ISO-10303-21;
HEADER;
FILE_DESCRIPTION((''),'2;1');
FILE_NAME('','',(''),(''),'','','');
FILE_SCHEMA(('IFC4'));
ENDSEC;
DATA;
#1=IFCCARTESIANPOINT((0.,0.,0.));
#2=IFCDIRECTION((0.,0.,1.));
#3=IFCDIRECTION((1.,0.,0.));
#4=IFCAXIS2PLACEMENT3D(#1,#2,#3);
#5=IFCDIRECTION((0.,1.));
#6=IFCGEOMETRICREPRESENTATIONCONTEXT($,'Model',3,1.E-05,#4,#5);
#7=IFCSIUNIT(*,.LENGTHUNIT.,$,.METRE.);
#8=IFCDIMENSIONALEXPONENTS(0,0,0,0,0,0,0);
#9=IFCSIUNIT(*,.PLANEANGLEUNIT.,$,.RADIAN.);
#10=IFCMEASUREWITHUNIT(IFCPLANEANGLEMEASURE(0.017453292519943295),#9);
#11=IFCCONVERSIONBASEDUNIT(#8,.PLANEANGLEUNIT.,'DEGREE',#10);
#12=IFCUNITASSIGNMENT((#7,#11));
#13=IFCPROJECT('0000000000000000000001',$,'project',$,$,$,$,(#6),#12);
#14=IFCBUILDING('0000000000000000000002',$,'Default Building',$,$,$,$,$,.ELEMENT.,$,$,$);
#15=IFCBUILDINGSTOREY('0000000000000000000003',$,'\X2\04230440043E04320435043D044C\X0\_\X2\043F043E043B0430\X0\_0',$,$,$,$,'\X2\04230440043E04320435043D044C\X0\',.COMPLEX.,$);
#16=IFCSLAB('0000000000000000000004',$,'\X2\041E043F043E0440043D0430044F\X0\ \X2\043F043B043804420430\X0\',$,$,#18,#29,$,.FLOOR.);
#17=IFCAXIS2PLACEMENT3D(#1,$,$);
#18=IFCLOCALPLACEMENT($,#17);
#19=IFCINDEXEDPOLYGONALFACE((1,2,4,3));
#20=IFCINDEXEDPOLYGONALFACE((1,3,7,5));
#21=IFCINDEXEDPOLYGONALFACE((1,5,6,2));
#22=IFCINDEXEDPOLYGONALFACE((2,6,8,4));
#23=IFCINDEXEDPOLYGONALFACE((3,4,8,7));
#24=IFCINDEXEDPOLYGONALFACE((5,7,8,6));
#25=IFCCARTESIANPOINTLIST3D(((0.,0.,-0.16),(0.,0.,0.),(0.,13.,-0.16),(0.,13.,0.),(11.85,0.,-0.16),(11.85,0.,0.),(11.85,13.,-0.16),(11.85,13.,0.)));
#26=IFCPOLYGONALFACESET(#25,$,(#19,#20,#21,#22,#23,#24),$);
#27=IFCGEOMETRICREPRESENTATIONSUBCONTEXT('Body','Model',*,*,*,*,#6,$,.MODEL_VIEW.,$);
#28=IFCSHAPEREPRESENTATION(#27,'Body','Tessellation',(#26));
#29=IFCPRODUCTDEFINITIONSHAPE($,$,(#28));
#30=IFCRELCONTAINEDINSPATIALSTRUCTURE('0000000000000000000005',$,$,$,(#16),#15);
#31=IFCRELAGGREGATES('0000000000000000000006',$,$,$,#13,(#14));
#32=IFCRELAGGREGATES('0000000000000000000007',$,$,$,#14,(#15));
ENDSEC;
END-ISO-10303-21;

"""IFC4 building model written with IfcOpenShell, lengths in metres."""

from ifc_helpers import new_model, entity, si_unit, converted_unit, direction, frame, origin_with_axes, origin_2d_with_axis, place, context, subcontext, project, spatial, rectangle, extrude, element, save


model = new_model("IFC4")

# Units and contexts
model_context = context("Model", 3, precision=1e-05, world=origin_with_axes(), true_north=direction((0.0, 1.0)))
body_context = subcontext(model_context, "Body", "Model", "MODEL_VIEW")
ifc_project = project(units=[si_unit("LENGTHUNIT", "METRE"), converted_unit("PLANEANGLEUNIT", "DEGREE", entity("IfcPlaneAngleMeasure", 0.017453292519943295), si_unit("PLANEANGLEUNIT", "RADIAN"), dimensions=[0, 0, 0, 0, 0, 0, 0])], contexts=[model_context])

# Building, storey
building = spatial("IfcBuilding", under=ifc_project, Name="Default Building", CompositionType="ELEMENT")
storey = spatial("IfcBuildingStorey", under=building, Name="Уровень_пола_0", LongName="Уровень", CompositionType="COMPLEX")

# Slab
slab_placement = place(None, origin_with_axes())
element("IfcSlab", 1, at=slab_placement, inside=storey, Name="Опорная плита", PredefinedType="FLOOR", context=body_context, shape_type="SweptSolid", body=[
    extrude(rectangle(XDim=11.85, YDim=13.0, at=origin_2d_with_axis()), frame((5.925, 6.5, 0.0), z_axis=(0.0, 0.0, 1.0), x_axis=(1.0, 0.0, 0.0)), (0.0, 0.0, -1.0), 0.16),
])

save(model, "model.ifc")
